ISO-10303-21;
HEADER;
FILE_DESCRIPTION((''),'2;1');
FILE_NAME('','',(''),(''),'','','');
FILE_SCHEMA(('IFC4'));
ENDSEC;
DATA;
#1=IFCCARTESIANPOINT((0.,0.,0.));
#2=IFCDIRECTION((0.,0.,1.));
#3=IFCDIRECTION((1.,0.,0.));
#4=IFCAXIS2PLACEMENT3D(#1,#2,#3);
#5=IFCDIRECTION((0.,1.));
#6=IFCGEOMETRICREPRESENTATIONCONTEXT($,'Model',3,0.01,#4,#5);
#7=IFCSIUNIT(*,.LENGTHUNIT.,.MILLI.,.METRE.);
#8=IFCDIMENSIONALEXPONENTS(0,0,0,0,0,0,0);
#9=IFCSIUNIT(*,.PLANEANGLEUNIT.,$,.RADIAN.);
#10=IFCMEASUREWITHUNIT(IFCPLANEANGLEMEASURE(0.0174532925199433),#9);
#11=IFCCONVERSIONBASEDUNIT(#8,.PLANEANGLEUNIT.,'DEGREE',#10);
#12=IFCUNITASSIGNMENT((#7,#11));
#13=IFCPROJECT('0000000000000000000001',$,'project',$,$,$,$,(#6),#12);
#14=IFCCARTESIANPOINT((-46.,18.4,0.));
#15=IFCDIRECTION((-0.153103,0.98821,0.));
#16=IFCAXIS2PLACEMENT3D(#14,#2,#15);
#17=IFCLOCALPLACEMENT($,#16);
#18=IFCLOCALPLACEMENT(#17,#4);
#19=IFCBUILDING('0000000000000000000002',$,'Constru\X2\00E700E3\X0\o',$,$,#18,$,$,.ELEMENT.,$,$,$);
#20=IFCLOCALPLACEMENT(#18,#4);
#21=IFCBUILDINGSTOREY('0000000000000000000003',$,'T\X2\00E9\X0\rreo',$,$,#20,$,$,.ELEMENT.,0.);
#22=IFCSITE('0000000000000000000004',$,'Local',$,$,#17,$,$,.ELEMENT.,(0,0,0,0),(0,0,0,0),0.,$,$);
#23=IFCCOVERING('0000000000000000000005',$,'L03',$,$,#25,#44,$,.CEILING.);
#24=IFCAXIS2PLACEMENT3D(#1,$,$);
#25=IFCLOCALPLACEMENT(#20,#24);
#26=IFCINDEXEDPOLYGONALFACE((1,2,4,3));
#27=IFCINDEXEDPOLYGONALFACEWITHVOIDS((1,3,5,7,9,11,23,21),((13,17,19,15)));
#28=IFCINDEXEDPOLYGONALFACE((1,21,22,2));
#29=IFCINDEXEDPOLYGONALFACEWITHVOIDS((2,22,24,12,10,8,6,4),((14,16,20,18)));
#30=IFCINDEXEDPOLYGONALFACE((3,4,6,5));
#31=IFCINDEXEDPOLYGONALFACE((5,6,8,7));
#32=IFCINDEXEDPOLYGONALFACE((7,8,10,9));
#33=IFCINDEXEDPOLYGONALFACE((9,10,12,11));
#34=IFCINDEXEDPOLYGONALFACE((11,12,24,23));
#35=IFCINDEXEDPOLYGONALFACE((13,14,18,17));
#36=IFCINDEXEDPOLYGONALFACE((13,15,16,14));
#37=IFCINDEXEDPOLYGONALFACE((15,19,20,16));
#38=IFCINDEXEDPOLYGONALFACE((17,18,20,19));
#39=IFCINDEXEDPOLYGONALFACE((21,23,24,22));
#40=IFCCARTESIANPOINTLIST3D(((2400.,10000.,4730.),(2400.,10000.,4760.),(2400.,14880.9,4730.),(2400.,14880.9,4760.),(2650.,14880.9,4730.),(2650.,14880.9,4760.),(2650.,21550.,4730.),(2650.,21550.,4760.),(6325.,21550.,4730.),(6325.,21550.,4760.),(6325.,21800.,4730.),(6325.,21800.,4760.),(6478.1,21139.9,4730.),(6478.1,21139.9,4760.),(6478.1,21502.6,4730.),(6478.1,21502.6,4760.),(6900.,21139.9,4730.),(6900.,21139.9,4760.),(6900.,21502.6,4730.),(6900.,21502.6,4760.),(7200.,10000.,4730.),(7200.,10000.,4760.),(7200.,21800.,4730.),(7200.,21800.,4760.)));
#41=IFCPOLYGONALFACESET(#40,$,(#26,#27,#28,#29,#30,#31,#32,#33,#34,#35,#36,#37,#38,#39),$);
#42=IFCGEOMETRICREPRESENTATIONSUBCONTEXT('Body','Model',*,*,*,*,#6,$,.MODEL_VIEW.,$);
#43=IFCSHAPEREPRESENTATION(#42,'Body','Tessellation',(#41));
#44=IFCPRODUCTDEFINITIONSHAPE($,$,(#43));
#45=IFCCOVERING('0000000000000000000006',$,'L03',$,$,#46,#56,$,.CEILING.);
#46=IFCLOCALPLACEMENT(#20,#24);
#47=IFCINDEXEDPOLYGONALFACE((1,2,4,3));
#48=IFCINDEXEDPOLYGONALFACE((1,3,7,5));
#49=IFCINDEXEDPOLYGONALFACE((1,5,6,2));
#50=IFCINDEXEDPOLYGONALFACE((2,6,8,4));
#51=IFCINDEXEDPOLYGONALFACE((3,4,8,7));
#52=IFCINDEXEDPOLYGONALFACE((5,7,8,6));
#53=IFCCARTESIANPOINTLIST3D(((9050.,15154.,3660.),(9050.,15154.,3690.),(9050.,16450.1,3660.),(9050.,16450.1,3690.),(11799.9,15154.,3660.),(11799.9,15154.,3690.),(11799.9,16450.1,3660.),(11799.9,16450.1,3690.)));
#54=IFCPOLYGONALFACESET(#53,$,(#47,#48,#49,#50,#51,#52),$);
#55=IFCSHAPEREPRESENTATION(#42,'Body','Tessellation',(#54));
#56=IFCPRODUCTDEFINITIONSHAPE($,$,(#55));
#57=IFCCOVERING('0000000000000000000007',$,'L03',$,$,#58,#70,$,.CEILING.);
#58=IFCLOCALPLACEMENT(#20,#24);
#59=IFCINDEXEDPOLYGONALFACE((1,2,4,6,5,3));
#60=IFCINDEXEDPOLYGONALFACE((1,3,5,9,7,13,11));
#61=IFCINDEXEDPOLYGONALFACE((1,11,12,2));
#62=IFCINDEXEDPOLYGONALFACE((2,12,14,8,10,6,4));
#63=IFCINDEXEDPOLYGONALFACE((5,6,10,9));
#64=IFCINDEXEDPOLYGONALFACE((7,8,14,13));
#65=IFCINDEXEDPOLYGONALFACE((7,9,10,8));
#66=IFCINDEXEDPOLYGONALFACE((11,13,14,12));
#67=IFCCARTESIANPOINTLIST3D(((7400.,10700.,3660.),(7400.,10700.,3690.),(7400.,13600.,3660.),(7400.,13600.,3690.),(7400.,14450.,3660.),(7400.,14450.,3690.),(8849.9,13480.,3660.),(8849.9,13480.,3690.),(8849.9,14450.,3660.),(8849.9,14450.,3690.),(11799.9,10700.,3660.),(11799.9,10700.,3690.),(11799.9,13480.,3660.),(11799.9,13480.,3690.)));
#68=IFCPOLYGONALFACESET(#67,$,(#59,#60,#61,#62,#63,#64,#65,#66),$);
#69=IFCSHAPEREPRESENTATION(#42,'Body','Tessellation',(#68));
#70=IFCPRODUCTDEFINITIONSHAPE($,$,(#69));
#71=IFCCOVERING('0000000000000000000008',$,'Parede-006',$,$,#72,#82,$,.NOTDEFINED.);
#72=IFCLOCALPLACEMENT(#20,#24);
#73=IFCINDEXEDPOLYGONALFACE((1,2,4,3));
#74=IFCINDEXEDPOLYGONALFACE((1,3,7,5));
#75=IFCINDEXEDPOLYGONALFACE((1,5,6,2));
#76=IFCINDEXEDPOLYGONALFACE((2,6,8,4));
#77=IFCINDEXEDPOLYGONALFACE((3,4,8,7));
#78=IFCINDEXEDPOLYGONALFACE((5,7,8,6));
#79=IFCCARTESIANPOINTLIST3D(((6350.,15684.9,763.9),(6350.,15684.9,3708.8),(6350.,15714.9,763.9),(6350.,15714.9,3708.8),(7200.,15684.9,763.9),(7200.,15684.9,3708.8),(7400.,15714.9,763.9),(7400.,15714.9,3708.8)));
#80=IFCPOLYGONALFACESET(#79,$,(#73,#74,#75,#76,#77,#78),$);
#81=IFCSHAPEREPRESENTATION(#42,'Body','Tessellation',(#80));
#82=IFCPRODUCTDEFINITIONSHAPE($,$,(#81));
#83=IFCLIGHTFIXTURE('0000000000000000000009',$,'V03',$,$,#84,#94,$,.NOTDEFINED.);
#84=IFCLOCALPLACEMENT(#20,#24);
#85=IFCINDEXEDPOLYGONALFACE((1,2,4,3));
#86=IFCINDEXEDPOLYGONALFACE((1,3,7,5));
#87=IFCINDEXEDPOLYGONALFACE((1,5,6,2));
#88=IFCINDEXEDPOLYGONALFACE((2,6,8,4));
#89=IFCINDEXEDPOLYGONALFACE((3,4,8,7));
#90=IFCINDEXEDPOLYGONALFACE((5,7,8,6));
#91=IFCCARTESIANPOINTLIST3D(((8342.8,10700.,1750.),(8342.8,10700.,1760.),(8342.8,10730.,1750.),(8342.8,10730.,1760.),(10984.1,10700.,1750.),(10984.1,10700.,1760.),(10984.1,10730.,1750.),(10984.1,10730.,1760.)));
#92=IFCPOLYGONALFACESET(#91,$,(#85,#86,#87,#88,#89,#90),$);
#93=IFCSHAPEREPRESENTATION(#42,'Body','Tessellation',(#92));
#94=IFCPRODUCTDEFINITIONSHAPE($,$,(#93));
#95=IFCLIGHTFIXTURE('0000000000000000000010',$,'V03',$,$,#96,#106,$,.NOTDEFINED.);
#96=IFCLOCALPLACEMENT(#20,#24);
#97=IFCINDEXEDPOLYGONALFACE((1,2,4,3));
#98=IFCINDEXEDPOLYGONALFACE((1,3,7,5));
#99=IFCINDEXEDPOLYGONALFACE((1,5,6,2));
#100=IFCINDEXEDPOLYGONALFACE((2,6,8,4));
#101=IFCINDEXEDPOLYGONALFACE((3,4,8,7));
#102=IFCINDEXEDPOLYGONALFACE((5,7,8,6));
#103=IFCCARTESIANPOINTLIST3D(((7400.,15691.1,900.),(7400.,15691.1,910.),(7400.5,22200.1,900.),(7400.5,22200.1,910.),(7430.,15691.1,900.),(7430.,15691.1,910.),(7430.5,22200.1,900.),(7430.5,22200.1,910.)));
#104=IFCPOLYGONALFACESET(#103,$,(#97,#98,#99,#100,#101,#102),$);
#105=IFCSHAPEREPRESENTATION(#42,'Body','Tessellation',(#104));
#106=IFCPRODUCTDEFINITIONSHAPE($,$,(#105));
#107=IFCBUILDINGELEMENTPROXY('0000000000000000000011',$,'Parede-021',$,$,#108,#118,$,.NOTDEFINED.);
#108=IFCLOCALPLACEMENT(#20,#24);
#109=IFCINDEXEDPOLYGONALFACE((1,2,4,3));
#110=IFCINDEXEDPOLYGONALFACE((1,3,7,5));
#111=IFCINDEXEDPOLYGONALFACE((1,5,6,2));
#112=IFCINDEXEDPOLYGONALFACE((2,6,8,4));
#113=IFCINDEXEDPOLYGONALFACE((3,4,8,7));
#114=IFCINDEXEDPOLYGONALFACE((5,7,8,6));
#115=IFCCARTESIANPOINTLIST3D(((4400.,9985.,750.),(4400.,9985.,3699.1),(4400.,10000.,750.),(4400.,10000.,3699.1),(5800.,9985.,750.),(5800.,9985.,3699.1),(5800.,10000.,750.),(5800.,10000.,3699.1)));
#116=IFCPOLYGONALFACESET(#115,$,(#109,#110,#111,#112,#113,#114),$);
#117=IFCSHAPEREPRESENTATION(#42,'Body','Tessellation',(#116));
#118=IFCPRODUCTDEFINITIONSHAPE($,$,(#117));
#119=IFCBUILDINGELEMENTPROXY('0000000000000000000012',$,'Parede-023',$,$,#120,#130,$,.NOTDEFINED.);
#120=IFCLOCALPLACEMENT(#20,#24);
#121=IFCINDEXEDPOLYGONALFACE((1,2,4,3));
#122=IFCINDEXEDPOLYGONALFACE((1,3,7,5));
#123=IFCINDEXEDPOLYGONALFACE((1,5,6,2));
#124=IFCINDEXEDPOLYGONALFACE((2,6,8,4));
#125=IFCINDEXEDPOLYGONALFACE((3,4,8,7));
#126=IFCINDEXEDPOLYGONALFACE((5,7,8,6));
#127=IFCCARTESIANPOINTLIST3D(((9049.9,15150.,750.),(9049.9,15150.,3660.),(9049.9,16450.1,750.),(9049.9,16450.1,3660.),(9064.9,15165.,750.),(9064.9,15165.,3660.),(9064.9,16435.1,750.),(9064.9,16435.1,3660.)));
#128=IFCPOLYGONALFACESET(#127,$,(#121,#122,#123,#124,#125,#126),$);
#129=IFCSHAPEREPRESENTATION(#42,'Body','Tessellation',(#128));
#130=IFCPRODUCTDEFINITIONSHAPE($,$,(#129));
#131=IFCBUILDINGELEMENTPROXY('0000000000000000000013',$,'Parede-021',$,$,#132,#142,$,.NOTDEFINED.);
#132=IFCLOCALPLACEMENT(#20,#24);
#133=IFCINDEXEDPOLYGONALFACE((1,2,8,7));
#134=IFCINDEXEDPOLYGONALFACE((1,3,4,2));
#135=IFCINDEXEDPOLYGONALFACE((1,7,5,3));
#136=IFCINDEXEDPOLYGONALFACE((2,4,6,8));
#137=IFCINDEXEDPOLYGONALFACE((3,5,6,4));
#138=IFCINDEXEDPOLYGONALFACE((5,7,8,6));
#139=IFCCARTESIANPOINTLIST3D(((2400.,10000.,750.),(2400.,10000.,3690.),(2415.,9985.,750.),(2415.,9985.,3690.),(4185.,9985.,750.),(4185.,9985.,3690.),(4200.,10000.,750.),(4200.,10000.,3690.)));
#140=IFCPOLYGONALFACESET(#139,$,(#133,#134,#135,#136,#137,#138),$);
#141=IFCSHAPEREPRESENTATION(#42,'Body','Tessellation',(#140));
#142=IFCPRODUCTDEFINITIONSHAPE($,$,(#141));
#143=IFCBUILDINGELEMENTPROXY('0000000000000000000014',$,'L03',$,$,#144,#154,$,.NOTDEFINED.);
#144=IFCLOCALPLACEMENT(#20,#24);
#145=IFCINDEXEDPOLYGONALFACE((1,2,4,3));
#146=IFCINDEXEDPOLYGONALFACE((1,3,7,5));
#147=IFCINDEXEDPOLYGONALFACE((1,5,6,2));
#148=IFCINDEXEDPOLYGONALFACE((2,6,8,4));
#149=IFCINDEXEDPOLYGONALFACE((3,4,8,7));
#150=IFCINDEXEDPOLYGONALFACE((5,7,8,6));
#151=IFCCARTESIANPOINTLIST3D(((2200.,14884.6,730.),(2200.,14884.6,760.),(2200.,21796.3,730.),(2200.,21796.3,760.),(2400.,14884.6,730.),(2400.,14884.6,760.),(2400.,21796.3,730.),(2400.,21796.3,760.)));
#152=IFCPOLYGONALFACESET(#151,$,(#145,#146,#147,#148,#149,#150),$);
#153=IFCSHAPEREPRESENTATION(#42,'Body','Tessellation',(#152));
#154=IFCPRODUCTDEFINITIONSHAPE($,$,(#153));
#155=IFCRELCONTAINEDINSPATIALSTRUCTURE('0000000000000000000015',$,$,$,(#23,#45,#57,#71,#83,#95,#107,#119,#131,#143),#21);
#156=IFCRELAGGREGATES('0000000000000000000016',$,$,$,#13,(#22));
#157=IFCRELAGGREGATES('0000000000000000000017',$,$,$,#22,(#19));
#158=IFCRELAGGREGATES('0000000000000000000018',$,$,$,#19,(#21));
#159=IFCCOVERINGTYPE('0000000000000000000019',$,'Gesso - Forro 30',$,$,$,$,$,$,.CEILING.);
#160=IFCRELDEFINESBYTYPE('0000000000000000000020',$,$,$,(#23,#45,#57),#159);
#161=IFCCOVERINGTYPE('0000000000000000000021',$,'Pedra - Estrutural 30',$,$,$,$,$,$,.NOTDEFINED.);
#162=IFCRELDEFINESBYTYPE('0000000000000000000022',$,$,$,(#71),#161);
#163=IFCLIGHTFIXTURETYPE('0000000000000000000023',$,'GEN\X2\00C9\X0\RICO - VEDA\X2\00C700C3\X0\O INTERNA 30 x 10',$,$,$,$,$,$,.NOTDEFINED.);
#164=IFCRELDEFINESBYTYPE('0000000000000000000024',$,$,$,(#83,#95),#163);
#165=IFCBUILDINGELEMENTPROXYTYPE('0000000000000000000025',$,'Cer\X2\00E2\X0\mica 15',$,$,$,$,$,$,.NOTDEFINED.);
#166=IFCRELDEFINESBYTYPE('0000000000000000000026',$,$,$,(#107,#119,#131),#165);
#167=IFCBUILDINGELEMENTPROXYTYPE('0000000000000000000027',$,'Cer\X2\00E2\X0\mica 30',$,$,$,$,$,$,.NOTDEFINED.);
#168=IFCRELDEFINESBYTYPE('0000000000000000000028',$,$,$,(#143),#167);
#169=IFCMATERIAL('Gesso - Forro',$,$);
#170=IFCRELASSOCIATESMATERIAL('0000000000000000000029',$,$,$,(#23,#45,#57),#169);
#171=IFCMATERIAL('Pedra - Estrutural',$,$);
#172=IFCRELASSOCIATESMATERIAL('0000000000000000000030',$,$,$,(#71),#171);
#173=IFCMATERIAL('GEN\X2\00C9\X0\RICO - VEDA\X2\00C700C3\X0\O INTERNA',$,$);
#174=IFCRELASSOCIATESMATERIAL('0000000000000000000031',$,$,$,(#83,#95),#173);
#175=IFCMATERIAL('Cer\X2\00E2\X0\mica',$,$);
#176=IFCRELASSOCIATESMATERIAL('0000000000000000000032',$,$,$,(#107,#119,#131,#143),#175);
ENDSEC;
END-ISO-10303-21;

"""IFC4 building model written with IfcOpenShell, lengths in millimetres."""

from ifc_helpers import new_model, entity, si_unit, converted_unit, direction, frame, frame_2d, origin_with_axes, place, context, subcontext, project, spatial, line, indexed_curve, rectangle, outline, extrude, material, type_object, element, save


model = new_model("IFC4")

# Units and contexts
model_context = context("Model", 3, precision=0.01, world=origin_with_axes(), true_north=direction((0.0, 1.0)))
body_context = subcontext(model_context, "Body", "Model", "MODEL_VIEW")
ifc_project = project(units=[si_unit("LENGTHUNIT", "METRE", prefix="MILLI"), converted_unit("PLANEANGLEUNIT", "DEGREE", entity("IfcPlaneAngleMeasure", 0.0174532925199433), si_unit("PLANEANGLEUNIT", "RADIAN"), dimensions=[0, 0, 0, 0, 0, 0, 0])], contexts=[model_context])

# Site, building, storey
site_placement = place(None, frame((-46.0, 18.4, 0.0), z_axis=(0.0, 0.0, 1.0), x_axis=(-0.153103, 0.98821, 0.0)))
site = spatial("IfcSite", under=ifc_project, at=site_placement, Name="Local", CompositionType="ELEMENT", RefLatitude=(0, 0, 0, 0), RefLongitude=(0, 0, 0, 0), RefElevation=0.0)
building_placement = place(site_placement, origin_with_axes())
building = spatial("IfcBuilding", under=site, at=building_placement, Name="Construção", CompositionType="ELEMENT")
storey_placement = place(building_placement, origin_with_axes())
storey = spatial("IfcBuildingStorey", under=building, at=storey_placement, Name="Térreo", CompositionType="ELEMENT", Elevation=0.0)

# Coverings
ifc_material_1 = material(Name="Gesso - Forro")
covering_type_1 = type_object("IfcCoveringType", Name="Gesso - Forro 30", PredefinedType="CEILING")
covering_1_placement = place(storey_placement, frame((2400.0, 10000.0, 4760.0), z_axis=(0.0, 0.0, 1.0), x_axis=(1.0, 0.0, 0.0)))
element("IfcCovering", 1, at=covering_1_placement, inside=storey, type_object=covering_type_1, material=ifc_material_1, Name="L03", PredefinedType="CEILING", context=body_context, shape_type="SweptSolid", body=[
    extrude(outline(indexed_curve([(0.0, 0.0), (4800.0, 0.0), (4800.0, 11800.0), (3925.0, 11800.0), (3925.0, 11550.0), (250.0, 11550.0), (250.0, 4880.9), (0.0, 4880.9), (4078.1, 11139.9), (4078.1, 11502.6), (4500.0, 11502.6), (4500.0, 11139.9)], segments=[line(1, 2, 3, 4, 5, 6, 7, 8, 1)]), holes=[indexed_curve([(0.0, 0.0), (4800.0, 0.0), (4800.0, 11800.0), (3925.0, 11800.0), (3925.0, 11550.0), (250.0, 11550.0), (250.0, 4880.9), (0.0, 4880.9), (4078.1, 11139.9), (4078.1, 11502.6), (4500.0, 11502.6), (4500.0, 11139.9)], segments=[line(9, 10, 11, 12, 9)])]), frame((0.0, 0.0, -30.0), z_axis=(0.0, 0.0, 1.0), x_axis=(1.0, 0.0, 0.0)), (0.0, 0.0, 1.0), 30.0),
])
covering_2_placement = place(storey_placement, frame((9050.0, 15154.0, 3690.0), z_axis=(0.0, 0.0, 1.0), x_axis=(1.0, 0.0, 0.0)))
element("IfcCovering", 2, at=covering_2_placement, inside=storey, type_object=covering_type_1, material=ifc_material_1, Name="L03", PredefinedType="CEILING", context=body_context, shape_type="SweptSolid", body=[
    extrude(outline(indexed_curve([(0.0, 0.0), (2749.9, 0.0), (2749.9, 1296.0), (0.0, 1296.0)], segments=[line(1, 2, 3, 4, 1)])), frame((0.0, 0.0, -30.0), z_axis=(0.0, 0.0, 1.0), x_axis=(1.0, 0.0, 0.0)), (0.0, 0.0, 1.0), 30.0),
])
covering_3_placement = place(storey_placement, frame((7400.0, 10700.0, 3690.0), z_axis=(0.0, 0.0, 1.0), x_axis=(1.0, 0.0, 0.0)))
element("IfcCovering", 3, at=covering_3_placement, inside=storey, type_object=covering_type_1, material=ifc_material_1, Name="L03", PredefinedType="CEILING", context=body_context, shape_type="SweptSolid", body=[
    extrude(outline(indexed_curve([(0.0, 0.0), (4400.0, 0.0), (4400.0, 2780.0), (1450.0, 2780.0), (1450.0, 3750.0), (0.0, 3750.0), (0.0, 2900.0)], segments=[line(1, 2, 3, 4, 5, 6, 7, 1)])), frame((0.0, 0.0, -30.0), z_axis=(0.0, 0.0, 1.0), x_axis=(1.0, 0.0, 0.0)), (0.0, 0.0, 1.0), 30.0),
])
ifc_material_2 = material(Name="Pedra - Estrutural")
covering_type_2 = type_object("IfcCoveringType", Name="Pedra - Estrutural 30", PredefinedType="NOTDEFINED")
covering_4_placement = place(storey_placement, frame((6350.0, 15684.9, 763.9), z_axis=(0.0, 0.0, 1.0), x_axis=(1.0, 0.0, 0.0)))
element("IfcCovering", 4, at=covering_4_placement, inside=storey, type_object=covering_type_2, material=ifc_material_2, Name="Parede-006", PredefinedType="NOTDEFINED", context=body_context, shape_type="SweptSolid", body=[
    extrude(outline(indexed_curve([(0.0, 0.0), (850.0, 0.0), (1050.0, 30.0), (0.0, 30.0)], segments=[line(1, 2, 3, 4, 1)])), origin_with_axes(), (0.0, 0.0, 1.0), 2944.9),
])

# Light fixtures
ifc_material_3 = material(Name="GENÉRICO - VEDAÇÃO INTERNA")
light_fixture_type = type_object("IfcLightFixtureType", Name="GENÉRICO - VEDAÇÃO INTERNA 30 x 10", PredefinedType="NOTDEFINED")
light_fixture_1_placement = place(storey_placement, frame((8342.8, 10700.0, 1760.0), z_axis=(0.0, 0.0, 1.0), x_axis=(0.0, -1.0, 0.0)))
element("IfcLightFixture", 5, at=light_fixture_1_placement, inside=storey, type_object=light_fixture_type, material=ifc_material_3, Name="V03", PredefinedType="NOTDEFINED", context=body_context, shape_type="SweptSolid", body=[
    extrude(rectangle(XDim=10.0, YDim=30.0, at=frame_2d((-5.0, -15.0), x_axis=(1.0, 0.0))), frame((0.0, 0.0, 0.0), z_axis=(0.0, 1.0, 0.0), x_axis=(0.0, 0.0, 1.0)), (0.0, 0.0, 1.0), 2641.4),
])
light_fixture_2_placement = place(storey_placement, frame((7430.0, 15691.1, 910.0), z_axis=(0.0, 0.0, 1.0), x_axis=(1.0, -0.000083, 0.0)))
element("IfcLightFixture", 6, at=light_fixture_2_placement, inside=storey, type_object=light_fixture_type, material=ifc_material_3, Name="V03", PredefinedType="NOTDEFINED", context=body_context, shape_type="SweptSolid", body=[
    extrude(rectangle(XDim=10.0, YDim=30.0, at=frame_2d((-5.0, -15.0), x_axis=(1.0, 0.0))), frame((0.0, 0.0, 0.0), z_axis=(0.0, 1.0, 0.0), x_axis=(0.0, 0.0, 1.0)), (0.0, 0.0, 1.0), 6509.0),
])

# Building element proxies
ifc_material_4 = material(Name="Cerâmica")
building_element_proxy_type_1 = type_object("IfcBuildingElementProxyType", Name="Cerâmica 15", PredefinedType="NOTDEFINED")
proxy_1_placement = place(storey_placement, frame((5800.0, 10000.0, 750.0), z_axis=(0.0, 0.0, 1.0), x_axis=(-1.0, 0.0, 0.0)))
element("IfcBuildingElementProxy", 7, at=proxy_1_placement, inside=storey, type_object=building_element_proxy_type_1, material=ifc_material_4, Name="Parede-021", PredefinedType="NOTDEFINED", context=body_context, shape_type="SweptSolid", body=[
    extrude(outline(indexed_curve([(0.0, 0.0), (1400.0, 0.0), (1400.0, 15.0), (0.0, 15.0)], segments=[line(1, 2, 3, 4, 1)])), origin_with_axes(), (0.0, 0.0, 1.0), 2949.1),
])
proxy_2_placement = place(storey_placement, frame((9049.9, 15150.0, 750.0), z_axis=(0.0, 0.0, 1.0), x_axis=(0.0, 1.0, 0.0)))
element("IfcBuildingElementProxy", 8, at=proxy_2_placement, inside=storey, type_object=building_element_proxy_type_1, material=ifc_material_4, Name="Parede-023", PredefinedType="NOTDEFINED", context=body_context, shape_type="SweptSolid", body=[
    extrude(outline(indexed_curve([(15.0, -15.0), (1285.1, -15.0), (1300.1, 0.0), (0.0, 0.0)], segments=[line(1, 2, 3, 4, 1)])), origin_with_axes(), (0.0, 0.0, 1.0), 2910.0),
])
proxy_3_placement = place(storey_placement, frame((4200.0, 10000.0, 750.0), z_axis=(0.0, 0.0, 1.0), x_axis=(-1.0, 0.0, 0.0)))
element("IfcBuildingElementProxy", 9, at=proxy_3_placement, inside=storey, type_object=building_element_proxy_type_1, material=ifc_material_4, Name="Parede-021", PredefinedType="NOTDEFINED", context=body_context, shape_type="SweptSolid", body=[
    extrude(outline(indexed_curve([(0.0, 0.0), (1800.0, 0.0), (1785.0, 15.0), (15.0, 15.0)], segments=[line(1, 2, 3, 4, 1)])), origin_with_axes(), (0.0, 0.0, 1.0), 2940.0),
])
building_element_proxy_type_2 = type_object("IfcBuildingElementProxyType", Name="Cerâmica 30", PredefinedType="NOTDEFINED")
proxy_4_placement = place(storey_placement, frame((2200.0, 14884.6, 760.0), z_axis=(0.0, 0.0, 1.0), x_axis=(1.0, 0.0, 0.0)))
element("IfcBuildingElementProxy", 10, at=proxy_4_placement, inside=storey, type_object=building_element_proxy_type_2, material=ifc_material_4, Name="L03", PredefinedType="NOTDEFINED", context=body_context, shape_type="SweptSolid", body=[
    extrude(outline(indexed_curve([(0.0, 0.0), (200.0, 0.0), (200.0, 6911.7), (0.0, 6911.7)], segments=[line(1, 2, 3, 4, 1)])), frame((0.0, 0.0, -30.0), z_axis=(0.0, 0.0, 1.0), x_axis=(1.0, 0.0, 0.0)), (0.0, 0.0, 1.0), 30.0),
])

save(model, "model.ifc")
